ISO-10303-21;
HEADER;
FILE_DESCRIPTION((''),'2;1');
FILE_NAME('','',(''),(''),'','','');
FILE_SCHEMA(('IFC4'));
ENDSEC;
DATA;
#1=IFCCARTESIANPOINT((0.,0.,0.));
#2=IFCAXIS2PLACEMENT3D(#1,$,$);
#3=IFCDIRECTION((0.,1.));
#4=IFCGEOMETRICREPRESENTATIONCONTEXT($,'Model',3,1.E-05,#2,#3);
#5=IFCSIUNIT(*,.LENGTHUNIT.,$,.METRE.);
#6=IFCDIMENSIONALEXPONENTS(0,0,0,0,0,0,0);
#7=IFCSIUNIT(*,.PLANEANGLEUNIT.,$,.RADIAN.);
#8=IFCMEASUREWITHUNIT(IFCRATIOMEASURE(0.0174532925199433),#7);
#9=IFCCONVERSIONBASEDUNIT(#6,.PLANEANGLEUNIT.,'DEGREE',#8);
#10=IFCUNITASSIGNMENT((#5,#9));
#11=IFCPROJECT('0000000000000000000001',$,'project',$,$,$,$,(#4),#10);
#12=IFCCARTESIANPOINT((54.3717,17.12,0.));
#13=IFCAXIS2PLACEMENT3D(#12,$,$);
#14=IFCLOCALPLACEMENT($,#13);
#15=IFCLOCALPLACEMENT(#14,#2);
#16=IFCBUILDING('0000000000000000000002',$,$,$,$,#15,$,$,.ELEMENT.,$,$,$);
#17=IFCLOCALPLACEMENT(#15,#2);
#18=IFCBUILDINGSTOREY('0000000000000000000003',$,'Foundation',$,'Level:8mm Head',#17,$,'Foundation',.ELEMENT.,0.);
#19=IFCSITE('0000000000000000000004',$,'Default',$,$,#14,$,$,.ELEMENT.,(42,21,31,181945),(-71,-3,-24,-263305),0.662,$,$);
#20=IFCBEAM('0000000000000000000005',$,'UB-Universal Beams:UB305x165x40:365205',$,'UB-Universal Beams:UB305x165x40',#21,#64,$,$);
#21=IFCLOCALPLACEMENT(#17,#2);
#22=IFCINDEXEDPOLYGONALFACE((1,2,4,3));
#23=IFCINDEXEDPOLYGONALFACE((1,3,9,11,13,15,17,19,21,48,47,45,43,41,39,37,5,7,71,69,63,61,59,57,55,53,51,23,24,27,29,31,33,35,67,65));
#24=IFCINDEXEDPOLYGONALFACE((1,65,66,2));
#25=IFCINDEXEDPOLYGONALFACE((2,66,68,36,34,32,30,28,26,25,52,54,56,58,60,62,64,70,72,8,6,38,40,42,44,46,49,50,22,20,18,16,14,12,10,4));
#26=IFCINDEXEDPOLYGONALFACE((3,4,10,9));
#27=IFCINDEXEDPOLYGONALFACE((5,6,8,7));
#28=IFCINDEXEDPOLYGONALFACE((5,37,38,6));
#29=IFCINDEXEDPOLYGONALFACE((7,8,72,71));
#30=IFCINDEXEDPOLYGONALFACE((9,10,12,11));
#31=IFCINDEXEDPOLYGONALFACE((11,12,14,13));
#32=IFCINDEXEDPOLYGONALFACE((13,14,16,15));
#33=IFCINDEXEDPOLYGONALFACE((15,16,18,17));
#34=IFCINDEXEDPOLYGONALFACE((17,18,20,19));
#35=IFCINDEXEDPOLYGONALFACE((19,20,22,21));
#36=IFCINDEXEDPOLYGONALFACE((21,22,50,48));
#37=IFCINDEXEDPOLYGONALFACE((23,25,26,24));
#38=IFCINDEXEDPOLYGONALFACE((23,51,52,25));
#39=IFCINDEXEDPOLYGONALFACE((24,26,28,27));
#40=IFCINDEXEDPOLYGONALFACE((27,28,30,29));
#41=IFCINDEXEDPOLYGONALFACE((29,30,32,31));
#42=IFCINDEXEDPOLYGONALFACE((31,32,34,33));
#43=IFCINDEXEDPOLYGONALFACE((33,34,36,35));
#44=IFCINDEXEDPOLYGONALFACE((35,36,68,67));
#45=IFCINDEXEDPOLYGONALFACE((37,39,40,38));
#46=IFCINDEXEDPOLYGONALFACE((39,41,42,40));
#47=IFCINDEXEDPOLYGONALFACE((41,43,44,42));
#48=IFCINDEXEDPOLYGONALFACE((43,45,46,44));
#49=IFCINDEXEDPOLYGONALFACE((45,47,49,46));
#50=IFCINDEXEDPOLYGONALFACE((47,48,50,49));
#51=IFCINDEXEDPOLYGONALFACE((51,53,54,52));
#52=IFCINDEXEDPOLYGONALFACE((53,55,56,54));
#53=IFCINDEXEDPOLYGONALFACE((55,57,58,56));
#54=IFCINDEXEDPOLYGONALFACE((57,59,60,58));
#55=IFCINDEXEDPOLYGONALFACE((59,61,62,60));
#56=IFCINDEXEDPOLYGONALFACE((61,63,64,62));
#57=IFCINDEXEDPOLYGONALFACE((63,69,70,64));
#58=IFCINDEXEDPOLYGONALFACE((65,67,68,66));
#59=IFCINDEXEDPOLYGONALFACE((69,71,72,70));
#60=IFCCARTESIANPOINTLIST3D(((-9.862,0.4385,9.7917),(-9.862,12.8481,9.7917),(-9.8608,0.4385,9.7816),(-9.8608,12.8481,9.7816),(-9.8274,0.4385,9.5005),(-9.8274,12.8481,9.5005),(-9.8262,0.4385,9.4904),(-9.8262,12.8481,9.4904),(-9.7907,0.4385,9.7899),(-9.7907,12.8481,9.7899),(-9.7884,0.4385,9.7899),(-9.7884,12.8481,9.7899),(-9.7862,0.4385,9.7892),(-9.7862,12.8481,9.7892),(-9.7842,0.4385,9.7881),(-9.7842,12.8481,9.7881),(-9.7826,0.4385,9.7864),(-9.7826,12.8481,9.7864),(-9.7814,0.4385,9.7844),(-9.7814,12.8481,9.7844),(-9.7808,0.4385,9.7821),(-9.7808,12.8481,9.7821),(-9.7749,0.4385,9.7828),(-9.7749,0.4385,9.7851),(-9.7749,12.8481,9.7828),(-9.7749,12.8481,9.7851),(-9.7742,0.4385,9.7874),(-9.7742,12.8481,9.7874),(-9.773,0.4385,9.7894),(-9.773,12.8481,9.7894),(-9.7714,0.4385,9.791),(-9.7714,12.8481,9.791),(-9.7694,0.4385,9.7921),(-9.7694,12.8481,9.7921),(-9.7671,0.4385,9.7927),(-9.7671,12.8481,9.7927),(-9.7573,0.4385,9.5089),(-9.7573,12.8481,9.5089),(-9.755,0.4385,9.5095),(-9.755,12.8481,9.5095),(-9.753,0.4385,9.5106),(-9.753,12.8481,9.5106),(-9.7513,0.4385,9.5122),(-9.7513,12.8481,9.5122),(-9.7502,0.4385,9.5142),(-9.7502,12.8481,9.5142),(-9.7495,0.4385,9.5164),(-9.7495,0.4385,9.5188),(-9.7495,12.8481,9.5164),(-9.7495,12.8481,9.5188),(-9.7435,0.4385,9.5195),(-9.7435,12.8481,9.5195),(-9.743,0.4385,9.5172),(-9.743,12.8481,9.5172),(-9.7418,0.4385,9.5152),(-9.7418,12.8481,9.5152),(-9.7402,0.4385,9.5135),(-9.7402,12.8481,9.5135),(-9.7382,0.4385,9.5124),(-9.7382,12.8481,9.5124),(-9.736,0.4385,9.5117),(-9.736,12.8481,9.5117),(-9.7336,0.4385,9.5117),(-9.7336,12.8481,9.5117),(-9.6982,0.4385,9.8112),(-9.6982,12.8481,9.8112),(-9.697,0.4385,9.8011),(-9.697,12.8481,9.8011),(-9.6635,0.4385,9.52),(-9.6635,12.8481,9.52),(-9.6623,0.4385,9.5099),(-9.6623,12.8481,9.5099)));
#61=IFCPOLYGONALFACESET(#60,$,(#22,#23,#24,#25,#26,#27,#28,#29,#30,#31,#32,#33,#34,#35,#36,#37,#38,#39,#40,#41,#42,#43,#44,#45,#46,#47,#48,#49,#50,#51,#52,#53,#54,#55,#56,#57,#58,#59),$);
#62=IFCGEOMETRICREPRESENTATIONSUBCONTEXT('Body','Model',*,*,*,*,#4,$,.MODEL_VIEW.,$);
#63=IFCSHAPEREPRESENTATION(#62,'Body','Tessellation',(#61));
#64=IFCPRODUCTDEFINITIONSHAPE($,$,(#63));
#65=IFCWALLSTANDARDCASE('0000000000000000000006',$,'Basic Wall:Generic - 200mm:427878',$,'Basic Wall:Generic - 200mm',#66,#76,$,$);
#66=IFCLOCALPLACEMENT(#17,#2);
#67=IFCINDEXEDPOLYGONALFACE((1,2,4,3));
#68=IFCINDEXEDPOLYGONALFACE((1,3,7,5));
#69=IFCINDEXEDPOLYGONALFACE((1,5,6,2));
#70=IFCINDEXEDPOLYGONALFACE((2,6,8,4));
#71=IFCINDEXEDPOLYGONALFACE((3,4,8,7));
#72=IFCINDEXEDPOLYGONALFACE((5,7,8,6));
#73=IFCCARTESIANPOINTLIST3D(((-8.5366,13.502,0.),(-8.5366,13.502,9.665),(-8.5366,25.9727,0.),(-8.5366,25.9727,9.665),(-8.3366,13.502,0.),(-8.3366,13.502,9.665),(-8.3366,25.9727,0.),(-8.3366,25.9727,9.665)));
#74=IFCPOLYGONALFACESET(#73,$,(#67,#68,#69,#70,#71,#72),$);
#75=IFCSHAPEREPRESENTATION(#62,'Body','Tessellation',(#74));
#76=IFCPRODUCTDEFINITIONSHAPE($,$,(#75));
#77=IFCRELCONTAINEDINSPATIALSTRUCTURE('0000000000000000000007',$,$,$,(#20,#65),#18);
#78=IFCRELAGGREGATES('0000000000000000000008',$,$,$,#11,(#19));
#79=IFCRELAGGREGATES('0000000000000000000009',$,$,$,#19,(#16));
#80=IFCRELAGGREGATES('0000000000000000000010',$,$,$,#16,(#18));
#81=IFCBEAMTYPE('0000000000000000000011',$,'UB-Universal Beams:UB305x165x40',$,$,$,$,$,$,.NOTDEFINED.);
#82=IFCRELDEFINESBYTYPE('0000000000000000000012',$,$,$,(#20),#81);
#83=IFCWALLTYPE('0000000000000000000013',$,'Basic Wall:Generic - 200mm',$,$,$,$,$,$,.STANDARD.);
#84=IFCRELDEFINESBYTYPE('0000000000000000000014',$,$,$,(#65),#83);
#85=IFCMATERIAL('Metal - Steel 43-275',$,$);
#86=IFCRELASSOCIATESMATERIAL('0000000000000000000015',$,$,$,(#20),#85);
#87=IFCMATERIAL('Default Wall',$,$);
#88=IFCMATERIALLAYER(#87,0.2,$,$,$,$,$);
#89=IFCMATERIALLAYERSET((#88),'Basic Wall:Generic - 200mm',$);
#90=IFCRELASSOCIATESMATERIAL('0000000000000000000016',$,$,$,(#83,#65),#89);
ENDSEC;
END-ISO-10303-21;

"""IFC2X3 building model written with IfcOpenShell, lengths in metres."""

from ifc_helpers import new_model, entity, si_unit, converted_unit, direction, frame, frame_2d, origin, place, context, subcontext, project, spatial, polyline, circle_curve, parameter, trimmed, segment, composite_curve, rectangle, outline, extrude, material, layer, layer_set, layer_usage, type_object, element, save


model = new_model("IFC2X3")

# Units and contexts
model_context = context("Model", 3, precision=1e-05, world=origin(), true_north=direction((0.0, 1.0)))
body_context = subcontext(model_context, "Body", "Model", "MODEL_VIEW")
ifc_project = project(units=[si_unit("LENGTHUNIT", "METRE"), converted_unit("PLANEANGLEUNIT", "DEGREE", entity("IfcRatioMeasure", 0.0174532925199433), si_unit("PLANEANGLEUNIT", "RADIAN"), dimensions=[0, 0, 0, 0, 0, 0, 0])], contexts=[model_context])

# Site, building, storey
site_placement = place(None, frame((54.3717, 17.12, 0.0)))
site = spatial("IfcSite", under=ifc_project, at=site_placement, Name="Default", CompositionType="ELEMENT", RefLatitude=(42, 21, 31, 181945), RefLongitude=(-71, -3, -24, -263305), RefElevation=0.662)
building_placement = place(site_placement, origin())
building = spatial("IfcBuilding", under=site, at=building_placement, CompositionType="ELEMENT")
storey_placement = place(building_placement, origin())
storey = spatial("IfcBuildingStorey", under=building, at=storey_placement, Name="Foundation", ObjectType="Level:8mm Head", LongName="Foundation", CompositionType="ELEMENT", Elevation=0.0)

# Beam
ifc_material_1 = material(Name="Metal - Steel 43-275")
beam_type = type_object("IfcBeamType", Name="UB-Universal Beams:UB305x165x40", PredefinedType="NOTDEFINED")
beam_placement = place(storey_placement, frame((-9.7441, 12.9433, 9.4986), z_axis=(0.0, 0.0, 1.0), x_axis=(0.0, -1.0, 0.0)))
element("IfcBeam", 1, at=beam_placement, inside=storey, type_object=beam_type, material=ifc_material_1, Name="UB-Universal Beams:UB305x165x40:365205", ObjectType="UB-Universal Beams:UB305x165x40", context=body_context, shape_type="SweptSolid", body=[
    extrude(outline(composite_curve([segment(polyline([(-0.0825, -0.1415), (-0.0825, -0.1517)]), True, "CONTINUOUS"), segment(polyline([(-0.0825, -0.1517), (0.0825, -0.1517)]), True, "CONTINUOUS"), segment(polyline([(0.0825, -0.1517), (0.0825, -0.1415)]), True, "CONTINUOUS"), segment(polyline([(0.0825, -0.1415), (0.0119, -0.1415)]), True, "CONTINUOUS"), segment(trimmed(circle_curve(frame_2d((0.0119, -0.1326), x_axis=(-1.0, 0.0)), 0.0089), [parameter(0.0)], [parameter(90.0)], True, "PARAMETER"), False, "CONTINUOUS"), segment(polyline([(0.003, -0.1326), (0.003, 0.1326)]), True, "CONTINUOUS"), segment(trimmed(circle_curve(frame_2d((0.0119, 0.1326), x_axis=(0.0, 1.0)), 0.0089), [parameter(0.0)], [parameter(90.0)], True, "PARAMETER"), False, "CONTINUOUS"), segment(polyline([(0.0119, 0.1415), (0.0825, 0.1415)]), True, "CONTINUOUS"), segment(polyline([(0.0825, 0.1415), (0.0825, 0.1517)]), True, "CONTINUOUS"), segment(polyline([(0.0825, 0.1517), (-0.0825, 0.1517)]), True, "CONTINUOUS"), segment(polyline([(-0.0825, 0.1517), (-0.0825, 0.1415)]), True, "CONTINUOUS"), segment(polyline([(-0.0825, 0.1415), (-0.0119, 0.1415)]), True, "CONTINUOUS"), segment(trimmed(circle_curve(frame_2d((-0.0119, 0.1326), x_axis=(1.0, 0.0)), 0.0089), [parameter(0.0)], [parameter(90.0)], True, "PARAMETER"), False, "CONTINUOUS"), segment(polyline([(-0.003, 0.1326), (-0.003, -0.1326)]), True, "CONTINUOUS"), segment(trimmed(circle_curve(frame_2d((-0.0119, -0.1326), x_axis=(0.0, -1.0)), 0.0089), [parameter(0.0)], [parameter(90.0)], True, "PARAMETER"), False, "CONTINUOUS"), segment(polyline([(-0.0119, -0.1415), (-0.0825, -0.1415)]), True, "CONTINUOUS")], self_intersect=False)), frame((0.0952, -0.0181, 0.1522), z_axis=(-1.0, 0.0, 0.0), x_axis=(0.0, -0.992988, -0.118213)), (0.0, 0.0, -1.0), 12.4096),
])

# Wall
ifc_material_2 = material(Name="Default Wall")
ifc_layer = layer(ifc_material_2, 0.2)
ifc_layer_set = layer_set([ifc_layer], Name="Basic Wall:Generic - 200mm")
ifc_layer_usage = layer_usage(ifc_layer_set, "AXIS2", "NEGATIVE", 0.1)
wall_type = type_object("IfcWallType", Name="Basic Wall:Generic - 200mm", PredefinedType="STANDARD", material=ifc_layer_set)
wall_placement = place(storey_placement, frame((-8.4366, 13.502, 0.0), z_axis=(0.0, 0.0, 1.0), x_axis=(0.0, 1.0, 0.0)))
element("IfcWallStandardCase", 2, at=wall_placement, inside=storey, type_object=wall_type, material=ifc_layer_usage, Name="Basic Wall:Generic - 200mm:427878", ObjectType="Basic Wall:Generic - 200mm", context=body_context, shape_type="SweptSolid", body=[
    extrude(rectangle(XDim=12.4707, YDim=0.2, at=frame_2d((6.2353, 0.0), x_axis=(-1.0, 0.0))), origin(), (0.0, 0.0, 1.0), 9.665),
])

save(model, "model.ifc")
